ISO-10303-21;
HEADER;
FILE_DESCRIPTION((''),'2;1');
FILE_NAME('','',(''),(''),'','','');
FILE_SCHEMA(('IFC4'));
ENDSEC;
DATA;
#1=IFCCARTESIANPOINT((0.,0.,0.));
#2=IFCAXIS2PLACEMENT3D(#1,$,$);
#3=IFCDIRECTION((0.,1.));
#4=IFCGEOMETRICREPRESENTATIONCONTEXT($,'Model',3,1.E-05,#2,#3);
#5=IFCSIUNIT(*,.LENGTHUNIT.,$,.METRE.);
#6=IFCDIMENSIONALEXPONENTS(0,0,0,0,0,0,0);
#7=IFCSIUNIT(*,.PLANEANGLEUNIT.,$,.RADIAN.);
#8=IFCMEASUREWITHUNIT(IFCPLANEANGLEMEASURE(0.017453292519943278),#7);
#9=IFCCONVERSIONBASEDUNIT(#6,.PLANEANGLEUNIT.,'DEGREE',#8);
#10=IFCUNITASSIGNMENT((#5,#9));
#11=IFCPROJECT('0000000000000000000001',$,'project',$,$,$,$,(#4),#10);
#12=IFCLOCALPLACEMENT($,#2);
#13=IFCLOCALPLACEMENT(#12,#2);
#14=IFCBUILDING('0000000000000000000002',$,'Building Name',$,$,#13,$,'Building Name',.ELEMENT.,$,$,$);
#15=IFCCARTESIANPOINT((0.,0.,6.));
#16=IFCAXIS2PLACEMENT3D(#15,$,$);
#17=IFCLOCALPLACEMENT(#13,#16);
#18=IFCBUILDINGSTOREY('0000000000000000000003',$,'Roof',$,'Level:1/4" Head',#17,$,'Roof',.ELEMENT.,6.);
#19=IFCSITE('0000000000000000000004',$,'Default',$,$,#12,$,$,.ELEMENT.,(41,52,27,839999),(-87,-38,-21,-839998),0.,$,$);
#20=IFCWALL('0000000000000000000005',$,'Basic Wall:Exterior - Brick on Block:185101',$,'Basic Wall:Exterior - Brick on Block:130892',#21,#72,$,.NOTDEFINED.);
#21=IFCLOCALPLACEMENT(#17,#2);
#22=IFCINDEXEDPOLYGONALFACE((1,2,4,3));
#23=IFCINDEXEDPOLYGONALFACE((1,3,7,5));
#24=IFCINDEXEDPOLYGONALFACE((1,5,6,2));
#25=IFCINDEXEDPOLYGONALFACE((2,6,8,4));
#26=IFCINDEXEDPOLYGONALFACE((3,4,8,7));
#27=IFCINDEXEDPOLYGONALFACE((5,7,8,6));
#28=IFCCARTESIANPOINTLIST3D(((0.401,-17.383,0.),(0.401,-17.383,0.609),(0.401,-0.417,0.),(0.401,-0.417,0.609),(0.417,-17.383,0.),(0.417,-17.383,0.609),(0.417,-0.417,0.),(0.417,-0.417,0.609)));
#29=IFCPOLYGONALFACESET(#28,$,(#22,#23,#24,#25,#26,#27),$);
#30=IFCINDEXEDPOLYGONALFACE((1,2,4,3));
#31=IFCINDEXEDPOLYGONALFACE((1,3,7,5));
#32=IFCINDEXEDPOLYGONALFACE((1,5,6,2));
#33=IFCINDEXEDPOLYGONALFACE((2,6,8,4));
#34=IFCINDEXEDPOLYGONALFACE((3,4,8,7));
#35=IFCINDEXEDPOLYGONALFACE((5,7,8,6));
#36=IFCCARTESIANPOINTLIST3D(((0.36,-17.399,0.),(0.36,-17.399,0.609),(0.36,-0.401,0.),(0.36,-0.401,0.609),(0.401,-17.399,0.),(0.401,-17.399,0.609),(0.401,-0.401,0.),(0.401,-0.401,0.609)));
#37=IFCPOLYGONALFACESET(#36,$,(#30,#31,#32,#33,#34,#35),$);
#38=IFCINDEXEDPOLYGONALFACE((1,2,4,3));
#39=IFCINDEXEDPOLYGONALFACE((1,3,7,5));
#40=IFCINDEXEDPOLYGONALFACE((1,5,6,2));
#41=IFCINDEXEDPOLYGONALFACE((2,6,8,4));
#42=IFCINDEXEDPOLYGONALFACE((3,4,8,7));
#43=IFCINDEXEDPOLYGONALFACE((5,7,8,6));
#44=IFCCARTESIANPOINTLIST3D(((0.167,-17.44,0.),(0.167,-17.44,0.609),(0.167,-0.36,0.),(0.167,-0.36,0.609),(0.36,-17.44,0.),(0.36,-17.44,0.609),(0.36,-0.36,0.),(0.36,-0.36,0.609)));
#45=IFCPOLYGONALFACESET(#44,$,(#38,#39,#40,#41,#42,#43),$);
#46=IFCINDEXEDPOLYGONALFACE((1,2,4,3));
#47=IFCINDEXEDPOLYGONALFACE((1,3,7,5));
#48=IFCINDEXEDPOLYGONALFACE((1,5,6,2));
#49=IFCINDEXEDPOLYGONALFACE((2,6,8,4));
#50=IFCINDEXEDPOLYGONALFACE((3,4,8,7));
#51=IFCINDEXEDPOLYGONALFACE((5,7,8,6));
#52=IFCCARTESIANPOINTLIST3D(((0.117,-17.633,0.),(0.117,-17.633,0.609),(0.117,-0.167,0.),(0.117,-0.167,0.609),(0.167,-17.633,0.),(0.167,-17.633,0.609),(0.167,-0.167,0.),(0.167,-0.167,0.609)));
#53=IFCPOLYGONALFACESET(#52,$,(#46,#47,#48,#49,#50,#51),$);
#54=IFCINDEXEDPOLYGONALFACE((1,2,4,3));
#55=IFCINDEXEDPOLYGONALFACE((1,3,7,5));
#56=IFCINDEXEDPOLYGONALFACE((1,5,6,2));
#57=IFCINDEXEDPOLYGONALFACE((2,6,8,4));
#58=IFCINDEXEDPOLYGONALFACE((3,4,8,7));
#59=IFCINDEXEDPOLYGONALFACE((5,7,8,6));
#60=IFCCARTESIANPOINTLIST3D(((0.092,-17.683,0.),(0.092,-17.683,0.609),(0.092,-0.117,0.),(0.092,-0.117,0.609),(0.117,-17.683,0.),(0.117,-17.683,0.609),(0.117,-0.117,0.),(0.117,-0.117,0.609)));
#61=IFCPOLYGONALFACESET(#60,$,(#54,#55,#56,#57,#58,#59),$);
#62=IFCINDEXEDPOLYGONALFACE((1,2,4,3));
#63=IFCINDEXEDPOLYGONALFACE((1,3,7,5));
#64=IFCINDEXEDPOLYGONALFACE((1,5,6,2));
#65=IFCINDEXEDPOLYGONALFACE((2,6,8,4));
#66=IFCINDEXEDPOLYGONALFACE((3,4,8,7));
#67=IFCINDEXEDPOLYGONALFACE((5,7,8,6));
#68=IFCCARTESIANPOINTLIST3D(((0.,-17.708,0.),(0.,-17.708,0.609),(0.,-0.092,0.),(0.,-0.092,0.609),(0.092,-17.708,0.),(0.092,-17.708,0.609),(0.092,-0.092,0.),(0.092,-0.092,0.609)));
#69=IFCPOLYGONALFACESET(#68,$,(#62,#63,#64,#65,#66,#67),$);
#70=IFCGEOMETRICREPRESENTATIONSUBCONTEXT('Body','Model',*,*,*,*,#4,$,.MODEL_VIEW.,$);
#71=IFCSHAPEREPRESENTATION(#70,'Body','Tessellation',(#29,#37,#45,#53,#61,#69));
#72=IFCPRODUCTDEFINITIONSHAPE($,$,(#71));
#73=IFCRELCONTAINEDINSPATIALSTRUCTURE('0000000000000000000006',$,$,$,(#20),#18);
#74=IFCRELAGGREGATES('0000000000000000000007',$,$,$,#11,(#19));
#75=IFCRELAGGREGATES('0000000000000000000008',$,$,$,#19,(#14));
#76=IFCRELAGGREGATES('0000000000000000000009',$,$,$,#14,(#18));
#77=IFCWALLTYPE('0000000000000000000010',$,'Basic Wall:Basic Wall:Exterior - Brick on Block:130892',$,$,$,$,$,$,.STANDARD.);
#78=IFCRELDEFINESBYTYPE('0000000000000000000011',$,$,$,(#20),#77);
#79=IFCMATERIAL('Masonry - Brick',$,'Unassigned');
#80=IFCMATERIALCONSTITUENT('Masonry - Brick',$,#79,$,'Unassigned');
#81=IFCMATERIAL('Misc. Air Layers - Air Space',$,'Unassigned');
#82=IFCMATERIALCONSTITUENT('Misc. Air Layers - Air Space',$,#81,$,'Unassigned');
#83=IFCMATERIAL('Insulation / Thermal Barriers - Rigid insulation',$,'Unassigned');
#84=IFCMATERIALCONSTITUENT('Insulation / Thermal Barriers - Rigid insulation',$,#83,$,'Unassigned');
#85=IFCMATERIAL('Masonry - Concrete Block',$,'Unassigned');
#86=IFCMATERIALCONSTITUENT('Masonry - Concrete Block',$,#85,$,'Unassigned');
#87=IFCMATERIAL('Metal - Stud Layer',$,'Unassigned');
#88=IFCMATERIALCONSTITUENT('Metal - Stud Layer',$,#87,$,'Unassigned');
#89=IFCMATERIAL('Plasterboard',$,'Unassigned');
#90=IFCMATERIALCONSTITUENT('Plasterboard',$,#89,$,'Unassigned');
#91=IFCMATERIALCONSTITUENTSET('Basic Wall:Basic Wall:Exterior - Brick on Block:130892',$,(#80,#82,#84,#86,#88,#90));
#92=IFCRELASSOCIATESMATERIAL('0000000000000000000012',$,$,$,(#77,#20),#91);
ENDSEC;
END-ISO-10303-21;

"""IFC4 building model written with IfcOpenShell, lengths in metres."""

from ifc_helpers import new_model, entity, si_unit, converted_unit, direction, frame, origin, place, context, subcontext, project, spatial, indexed_curve, outline, extrude, material, constituent, constituent_set, type_object, element, save


model = new_model("IFC4")

# Units and contexts
model_context = context("Model", 3, precision=1e-05, world=origin(), true_north=direction((0.0, 1.0)))
body_context = subcontext(model_context, "Body", "Model", "MODEL_VIEW")
ifc_project = project(units=[si_unit("LENGTHUNIT", "METRE"), converted_unit("PLANEANGLEUNIT", "DEGREE", entity("IfcPlaneAngleMeasure", 0.017453292519943278), si_unit("PLANEANGLEUNIT", "RADIAN"), dimensions=[0, 0, 0, 0, 0, 0, 0])], contexts=[model_context])

# Site, building, storey
site_placement = place(None, origin())
site = spatial("IfcSite", under=ifc_project, at=site_placement, Name="Default", CompositionType="ELEMENT", RefLatitude=(41, 52, 27, 839999), RefLongitude=(-87, -38, -21, -839998), RefElevation=0.0)
building_placement = place(site_placement, origin())
building = spatial("IfcBuilding", under=site, at=building_placement, Name="Building Name", LongName="Building Name", CompositionType="ELEMENT")
storey_placement = place(building_placement, frame((0.0, 0.0, 6.0)))
storey = spatial("IfcBuildingStorey", under=building, at=storey_placement, Name="Roof", ObjectType="Level:1/4\" Head", LongName="Roof", CompositionType="ELEMENT", Elevation=6.0)

# Shared definitions
ifc_material_1 = material(Name="Insulation / Thermal Barriers - Rigid insulation", Category="Unassigned")

# Wall
ifc_material_2 = material(Name="Masonry - Brick", Category="Unassigned")
ifc_constituent_1 = constituent(ifc_material_2, Name="Masonry - Brick", Category="Unassigned")
ifc_material_3 = material(Name="Misc. Air Layers - Air Space", Category="Unassigned")
ifc_constituent_2 = constituent(ifc_material_3, Name="Misc. Air Layers - Air Space", Category="Unassigned")
ifc_constituent_3 = constituent(ifc_material_1, Name="Insulation / Thermal Barriers - Rigid insulation", Category="Unassigned")
ifc_material_4 = material(Name="Masonry - Concrete Block", Category="Unassigned")
ifc_constituent_4 = constituent(ifc_material_4, Name="Masonry - Concrete Block", Category="Unassigned")
ifc_material_5 = material(Name="Metal - Stud Layer", Category="Unassigned")
ifc_constituent_5 = constituent(ifc_material_5, Name="Metal - Stud Layer", Category="Unassigned")
ifc_material_6 = material(Name="Plasterboard", Category="Unassigned")
ifc_constituent_6 = constituent(ifc_material_6, Name="Plasterboard", Category="Unassigned")
ifc_constituent_set_1 = constituent_set(constituents=[ifc_constituent_1, ifc_constituent_2, ifc_constituent_3, ifc_constituent_4, ifc_constituent_5, ifc_constituent_6], Name="Basic Wall:Basic Wall:Exterior - Brick on Block:130892")
wall_type = type_object("IfcWallType", Name="Basic Wall:Basic Wall:Exterior - Brick on Block:130892", PredefinedType="STANDARD", material=ifc_constituent_set_1)
wall_1_placement = place(storey_placement, frame((0.2085, -17.383, 0.0), z_axis=(0.0, 0.0, 1.0), x_axis=(0.0, 1.0, 0.0)))
element("IfcWall", 1, at=wall_1_placement, inside=storey, type_object=wall_type, material=ifc_constituent_set_1, Name="Basic Wall:Exterior - Brick on Block:185101", ObjectType="Basic Wall:Exterior - Brick on Block:130892", PredefinedType="NOTDEFINED", context=body_context, shape_type="SweptSolid", body=[
    extrude(outline(indexed_curve([(-0.008, -8.483), (0.008, -8.483), (0.008, 8.483), (-0.008, 8.483), (-0.008, -8.483)], self_intersect=False)), frame((8.483, -0.2005, 0.0), z_axis=(0.0, 0.0, 1.0), x_axis=(0.0, 1.0, 0.0)), (0.0, 0.0, 1.0), 0.609),
    extrude(outline(indexed_curve([(-8.499, -0.0205), (8.499, -0.0205), (8.499, 0.0205), (-8.499, 0.0205), (-8.499, -0.0205)], self_intersect=False)), frame((8.483, -0.172, 0.0)), (0.0, 0.0, 1.0), 0.609),
    extrude(outline(indexed_curve([(-8.54, -0.0965), (8.54, -0.0965), (8.54, 0.0965), (-8.54, 0.0965), (-8.54, -0.0965)], self_intersect=False)), frame((8.483, -0.055, 0.0)), (0.0, 0.0, 1.0), 0.609),
    extrude(outline(indexed_curve([(-8.733, -0.025), (8.733, -0.025), (8.733, 0.025), (-8.733, 0.025), (-8.733, -0.025)], self_intersect=False)), frame((8.483, 0.0665, 0.0)), (0.0, 0.0, 1.0), 0.609),
    extrude(outline(indexed_curve([(-8.783, -0.0125), (8.783, -0.0125), (8.783, 0.0125), (-8.783, 0.0125), (-8.783, -0.0125)], self_intersect=False)), frame((8.483, 0.104, 0.0)), (0.0, 0.0, 1.0), 0.609),
    extrude(outline(indexed_curve([(-0.046, -8.808), (0.046, -8.808), (0.046, 8.808), (-0.046, 8.808), (-0.046, -8.808)], self_intersect=False)), frame((8.483, 0.1625, 0.0), z_axis=(0.0, 0.0, 1.0), x_axis=(0.0, -1.0, 0.0)), (0.0, 0.0, 1.0), 0.609),
])

save(model, "model.ifc")
